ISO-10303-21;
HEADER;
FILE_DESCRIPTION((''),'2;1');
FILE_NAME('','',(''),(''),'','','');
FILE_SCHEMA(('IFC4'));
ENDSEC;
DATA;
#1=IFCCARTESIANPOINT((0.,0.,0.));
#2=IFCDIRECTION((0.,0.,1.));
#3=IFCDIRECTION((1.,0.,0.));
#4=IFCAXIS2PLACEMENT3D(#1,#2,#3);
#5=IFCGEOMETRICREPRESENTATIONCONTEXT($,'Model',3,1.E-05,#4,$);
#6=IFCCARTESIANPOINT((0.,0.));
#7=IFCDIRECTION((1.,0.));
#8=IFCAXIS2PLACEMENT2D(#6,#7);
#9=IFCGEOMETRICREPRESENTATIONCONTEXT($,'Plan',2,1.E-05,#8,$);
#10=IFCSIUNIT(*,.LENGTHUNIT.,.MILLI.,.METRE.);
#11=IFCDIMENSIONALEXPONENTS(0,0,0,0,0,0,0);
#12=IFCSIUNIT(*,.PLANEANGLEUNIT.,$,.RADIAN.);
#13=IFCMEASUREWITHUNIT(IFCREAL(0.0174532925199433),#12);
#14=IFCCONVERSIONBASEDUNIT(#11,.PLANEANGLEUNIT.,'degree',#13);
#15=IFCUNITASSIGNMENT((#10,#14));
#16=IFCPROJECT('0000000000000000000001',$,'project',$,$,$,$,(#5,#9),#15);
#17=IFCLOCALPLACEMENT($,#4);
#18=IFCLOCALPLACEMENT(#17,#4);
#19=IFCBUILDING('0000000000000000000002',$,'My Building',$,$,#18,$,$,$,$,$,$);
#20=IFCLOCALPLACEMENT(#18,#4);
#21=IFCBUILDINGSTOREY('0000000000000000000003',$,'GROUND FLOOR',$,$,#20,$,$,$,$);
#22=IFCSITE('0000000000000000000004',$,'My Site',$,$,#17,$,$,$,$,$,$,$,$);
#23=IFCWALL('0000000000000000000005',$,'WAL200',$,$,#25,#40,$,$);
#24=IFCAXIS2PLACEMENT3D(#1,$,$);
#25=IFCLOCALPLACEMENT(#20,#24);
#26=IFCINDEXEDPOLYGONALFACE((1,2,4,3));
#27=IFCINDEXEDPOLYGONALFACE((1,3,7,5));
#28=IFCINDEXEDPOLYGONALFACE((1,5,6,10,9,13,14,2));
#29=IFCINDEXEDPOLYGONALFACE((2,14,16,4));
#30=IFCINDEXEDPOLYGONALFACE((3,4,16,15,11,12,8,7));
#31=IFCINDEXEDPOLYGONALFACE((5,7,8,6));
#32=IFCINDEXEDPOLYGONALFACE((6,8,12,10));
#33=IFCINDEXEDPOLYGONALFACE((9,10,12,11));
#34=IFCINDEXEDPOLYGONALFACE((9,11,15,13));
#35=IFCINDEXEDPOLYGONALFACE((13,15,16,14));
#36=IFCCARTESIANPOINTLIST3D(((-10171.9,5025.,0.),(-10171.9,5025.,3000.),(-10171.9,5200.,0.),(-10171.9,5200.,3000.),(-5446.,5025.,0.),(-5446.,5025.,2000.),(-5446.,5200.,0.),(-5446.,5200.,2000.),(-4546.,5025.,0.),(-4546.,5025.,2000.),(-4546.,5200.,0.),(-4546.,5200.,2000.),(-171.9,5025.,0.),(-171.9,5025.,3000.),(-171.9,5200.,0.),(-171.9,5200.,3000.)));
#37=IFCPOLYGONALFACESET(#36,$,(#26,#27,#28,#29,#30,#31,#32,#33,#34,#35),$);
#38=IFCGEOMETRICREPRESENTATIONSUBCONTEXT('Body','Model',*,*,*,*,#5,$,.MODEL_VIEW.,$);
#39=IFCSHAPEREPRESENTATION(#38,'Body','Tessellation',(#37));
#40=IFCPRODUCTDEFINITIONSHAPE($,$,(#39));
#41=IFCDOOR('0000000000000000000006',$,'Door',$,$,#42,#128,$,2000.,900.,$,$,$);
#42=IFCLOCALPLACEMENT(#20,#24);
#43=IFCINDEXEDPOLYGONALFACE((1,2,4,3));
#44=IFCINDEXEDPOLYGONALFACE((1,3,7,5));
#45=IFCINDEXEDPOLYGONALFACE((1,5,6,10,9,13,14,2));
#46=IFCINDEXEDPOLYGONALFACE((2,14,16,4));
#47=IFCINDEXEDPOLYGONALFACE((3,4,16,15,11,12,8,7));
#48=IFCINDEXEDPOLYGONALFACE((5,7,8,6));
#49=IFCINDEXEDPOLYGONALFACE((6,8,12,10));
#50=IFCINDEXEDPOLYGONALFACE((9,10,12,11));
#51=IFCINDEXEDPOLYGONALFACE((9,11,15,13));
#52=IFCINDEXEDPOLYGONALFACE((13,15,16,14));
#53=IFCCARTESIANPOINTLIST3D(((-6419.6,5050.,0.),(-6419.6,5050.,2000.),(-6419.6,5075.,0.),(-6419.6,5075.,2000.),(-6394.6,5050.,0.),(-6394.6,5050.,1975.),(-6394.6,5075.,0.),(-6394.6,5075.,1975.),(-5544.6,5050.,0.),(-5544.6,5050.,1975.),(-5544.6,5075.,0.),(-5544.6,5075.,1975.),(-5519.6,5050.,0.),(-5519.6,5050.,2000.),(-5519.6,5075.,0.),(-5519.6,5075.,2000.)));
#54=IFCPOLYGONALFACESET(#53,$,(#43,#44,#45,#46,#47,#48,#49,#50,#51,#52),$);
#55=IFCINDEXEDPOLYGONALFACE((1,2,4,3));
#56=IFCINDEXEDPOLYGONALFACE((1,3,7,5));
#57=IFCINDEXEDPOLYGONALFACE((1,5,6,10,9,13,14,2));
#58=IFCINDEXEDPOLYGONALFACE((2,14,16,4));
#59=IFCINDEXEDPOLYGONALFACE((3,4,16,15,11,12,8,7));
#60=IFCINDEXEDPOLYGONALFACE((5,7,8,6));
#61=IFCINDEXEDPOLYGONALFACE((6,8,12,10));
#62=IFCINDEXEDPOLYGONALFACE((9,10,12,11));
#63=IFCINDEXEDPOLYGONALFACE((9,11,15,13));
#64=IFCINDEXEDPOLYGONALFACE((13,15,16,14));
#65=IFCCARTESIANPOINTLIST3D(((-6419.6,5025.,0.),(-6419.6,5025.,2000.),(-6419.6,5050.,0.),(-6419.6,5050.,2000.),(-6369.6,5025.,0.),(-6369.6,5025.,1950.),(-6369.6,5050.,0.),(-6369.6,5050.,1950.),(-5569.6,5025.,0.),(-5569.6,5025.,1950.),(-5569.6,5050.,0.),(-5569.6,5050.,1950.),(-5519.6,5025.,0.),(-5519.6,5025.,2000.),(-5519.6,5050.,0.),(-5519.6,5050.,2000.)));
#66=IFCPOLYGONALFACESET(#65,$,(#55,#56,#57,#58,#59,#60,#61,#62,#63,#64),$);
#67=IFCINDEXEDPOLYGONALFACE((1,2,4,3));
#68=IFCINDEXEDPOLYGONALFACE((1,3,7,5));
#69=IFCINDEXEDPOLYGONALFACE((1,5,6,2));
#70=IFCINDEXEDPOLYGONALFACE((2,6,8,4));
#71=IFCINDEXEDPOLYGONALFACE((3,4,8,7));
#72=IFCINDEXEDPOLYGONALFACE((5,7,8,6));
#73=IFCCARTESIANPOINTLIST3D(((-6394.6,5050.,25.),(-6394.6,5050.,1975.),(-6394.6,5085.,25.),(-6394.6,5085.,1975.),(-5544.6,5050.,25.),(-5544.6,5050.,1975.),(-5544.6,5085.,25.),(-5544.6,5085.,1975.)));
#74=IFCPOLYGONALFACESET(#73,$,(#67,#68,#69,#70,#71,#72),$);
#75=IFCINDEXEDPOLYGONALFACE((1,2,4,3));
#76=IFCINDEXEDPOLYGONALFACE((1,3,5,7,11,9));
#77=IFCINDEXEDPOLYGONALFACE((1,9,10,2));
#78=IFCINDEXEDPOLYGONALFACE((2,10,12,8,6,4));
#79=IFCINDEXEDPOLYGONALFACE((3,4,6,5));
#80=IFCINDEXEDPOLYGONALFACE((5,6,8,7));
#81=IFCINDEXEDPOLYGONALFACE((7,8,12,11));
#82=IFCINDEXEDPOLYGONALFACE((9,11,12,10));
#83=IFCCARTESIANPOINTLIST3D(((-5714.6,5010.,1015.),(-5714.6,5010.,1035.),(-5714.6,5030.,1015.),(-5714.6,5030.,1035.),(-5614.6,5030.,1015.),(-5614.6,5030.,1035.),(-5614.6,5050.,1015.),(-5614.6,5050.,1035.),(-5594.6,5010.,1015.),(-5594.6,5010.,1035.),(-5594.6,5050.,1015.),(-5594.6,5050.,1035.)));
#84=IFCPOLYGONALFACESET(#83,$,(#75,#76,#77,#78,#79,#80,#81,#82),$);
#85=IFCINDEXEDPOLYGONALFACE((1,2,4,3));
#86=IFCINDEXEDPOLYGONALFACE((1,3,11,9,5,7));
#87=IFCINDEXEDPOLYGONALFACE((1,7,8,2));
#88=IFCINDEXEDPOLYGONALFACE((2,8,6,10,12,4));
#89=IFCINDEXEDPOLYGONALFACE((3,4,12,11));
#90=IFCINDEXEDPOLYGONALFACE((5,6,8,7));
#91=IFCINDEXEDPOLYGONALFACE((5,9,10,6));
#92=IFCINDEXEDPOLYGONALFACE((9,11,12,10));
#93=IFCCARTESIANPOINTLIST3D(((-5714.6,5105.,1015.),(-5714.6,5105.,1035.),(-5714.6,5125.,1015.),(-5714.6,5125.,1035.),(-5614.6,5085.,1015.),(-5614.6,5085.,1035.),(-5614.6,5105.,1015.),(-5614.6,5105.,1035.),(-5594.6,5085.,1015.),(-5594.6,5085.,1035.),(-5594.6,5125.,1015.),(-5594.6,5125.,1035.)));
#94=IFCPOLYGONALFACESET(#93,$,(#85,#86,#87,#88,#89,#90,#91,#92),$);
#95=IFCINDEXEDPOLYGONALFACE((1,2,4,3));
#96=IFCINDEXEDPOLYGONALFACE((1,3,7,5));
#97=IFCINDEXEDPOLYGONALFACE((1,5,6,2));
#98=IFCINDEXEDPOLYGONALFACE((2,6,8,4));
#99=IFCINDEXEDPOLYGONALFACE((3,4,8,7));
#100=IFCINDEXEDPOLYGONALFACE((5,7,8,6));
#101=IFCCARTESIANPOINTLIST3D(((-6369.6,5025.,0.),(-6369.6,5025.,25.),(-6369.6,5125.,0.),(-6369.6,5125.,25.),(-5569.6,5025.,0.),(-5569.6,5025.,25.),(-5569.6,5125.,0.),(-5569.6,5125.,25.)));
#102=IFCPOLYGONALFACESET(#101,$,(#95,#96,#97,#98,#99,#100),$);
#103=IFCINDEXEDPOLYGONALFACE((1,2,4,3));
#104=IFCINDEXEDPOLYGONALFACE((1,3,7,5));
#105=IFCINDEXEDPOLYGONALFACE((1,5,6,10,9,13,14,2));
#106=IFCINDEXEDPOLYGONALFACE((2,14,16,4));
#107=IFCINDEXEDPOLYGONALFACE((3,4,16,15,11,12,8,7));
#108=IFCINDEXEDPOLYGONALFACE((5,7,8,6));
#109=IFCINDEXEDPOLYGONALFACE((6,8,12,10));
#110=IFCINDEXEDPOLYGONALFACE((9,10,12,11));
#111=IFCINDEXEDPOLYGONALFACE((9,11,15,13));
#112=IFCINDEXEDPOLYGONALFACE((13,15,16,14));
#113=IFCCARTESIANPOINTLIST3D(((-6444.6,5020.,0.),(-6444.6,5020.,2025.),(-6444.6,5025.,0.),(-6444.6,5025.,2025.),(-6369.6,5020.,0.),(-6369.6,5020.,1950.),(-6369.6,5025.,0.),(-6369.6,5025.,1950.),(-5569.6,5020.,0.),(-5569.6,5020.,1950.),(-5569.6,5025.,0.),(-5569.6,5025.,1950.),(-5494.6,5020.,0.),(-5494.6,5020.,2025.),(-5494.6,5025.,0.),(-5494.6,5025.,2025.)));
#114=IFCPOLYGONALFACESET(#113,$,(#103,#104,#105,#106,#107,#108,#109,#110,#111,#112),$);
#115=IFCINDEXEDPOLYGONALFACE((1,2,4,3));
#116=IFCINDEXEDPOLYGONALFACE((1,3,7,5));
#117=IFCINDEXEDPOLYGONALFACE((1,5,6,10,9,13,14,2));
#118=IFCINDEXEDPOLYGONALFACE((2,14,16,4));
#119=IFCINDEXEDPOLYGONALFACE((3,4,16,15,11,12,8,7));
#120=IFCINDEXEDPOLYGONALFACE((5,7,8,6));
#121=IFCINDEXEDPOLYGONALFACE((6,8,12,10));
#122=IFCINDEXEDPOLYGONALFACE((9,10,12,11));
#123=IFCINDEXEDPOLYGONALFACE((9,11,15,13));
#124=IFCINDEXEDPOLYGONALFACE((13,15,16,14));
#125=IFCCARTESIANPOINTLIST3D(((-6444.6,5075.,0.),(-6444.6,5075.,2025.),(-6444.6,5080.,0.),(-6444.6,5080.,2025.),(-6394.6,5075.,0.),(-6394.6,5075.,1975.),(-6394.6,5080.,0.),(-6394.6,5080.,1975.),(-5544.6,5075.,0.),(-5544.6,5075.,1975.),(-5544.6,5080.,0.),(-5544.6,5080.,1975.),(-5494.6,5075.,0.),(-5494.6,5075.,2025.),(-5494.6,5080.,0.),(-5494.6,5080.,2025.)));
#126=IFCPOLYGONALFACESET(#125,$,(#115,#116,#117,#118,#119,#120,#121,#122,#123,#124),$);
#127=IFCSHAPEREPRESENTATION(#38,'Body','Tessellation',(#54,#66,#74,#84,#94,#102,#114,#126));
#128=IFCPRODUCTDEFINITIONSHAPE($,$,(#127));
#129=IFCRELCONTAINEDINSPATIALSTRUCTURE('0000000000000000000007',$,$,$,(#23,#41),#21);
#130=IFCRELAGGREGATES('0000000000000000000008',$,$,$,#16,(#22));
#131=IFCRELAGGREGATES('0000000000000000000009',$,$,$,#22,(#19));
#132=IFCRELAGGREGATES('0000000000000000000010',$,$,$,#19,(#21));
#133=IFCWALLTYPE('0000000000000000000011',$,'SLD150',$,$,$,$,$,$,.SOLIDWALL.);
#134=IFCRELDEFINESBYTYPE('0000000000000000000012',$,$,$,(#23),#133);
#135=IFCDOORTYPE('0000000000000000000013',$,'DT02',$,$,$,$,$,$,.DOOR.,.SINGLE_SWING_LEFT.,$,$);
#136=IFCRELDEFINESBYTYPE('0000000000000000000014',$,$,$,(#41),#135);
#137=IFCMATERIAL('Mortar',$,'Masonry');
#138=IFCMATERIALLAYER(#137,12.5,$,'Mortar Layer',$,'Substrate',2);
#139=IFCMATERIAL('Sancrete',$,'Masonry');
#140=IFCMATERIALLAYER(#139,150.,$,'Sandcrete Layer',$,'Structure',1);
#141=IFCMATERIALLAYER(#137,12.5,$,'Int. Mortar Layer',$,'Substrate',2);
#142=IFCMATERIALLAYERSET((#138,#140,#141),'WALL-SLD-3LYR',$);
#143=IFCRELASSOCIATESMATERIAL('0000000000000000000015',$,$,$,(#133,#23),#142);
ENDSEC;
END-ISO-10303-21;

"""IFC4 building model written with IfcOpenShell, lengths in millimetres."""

from ifc_helpers import new_model, entity, si_unit, converted_unit, frame, origin_with_axes, origin_2d_with_axis, place, context, subcontext, project, spatial, line, indexed_curve, outline, extrude, shape, source, transform, mapped, material, layer, layer_set, layer_usage, type_object, type_shapes, element, fill, save


model = new_model("IFC4")

# Units and contexts
model_context = context("Model", 3, precision=1e-05, world=origin_with_axes())
plan_context = context("Plan", 2, precision=1e-05, world=origin_2d_with_axis())
body_context_1 = subcontext(model_context, "Body", "Model", "MODEL_VIEW")
body_context_2 = subcontext(plan_context, "Body", "Plan", "PLAN_VIEW")
ifc_project = project(units=[si_unit("LENGTHUNIT", "METRE", prefix="MILLI"), converted_unit("PLANEANGLEUNIT", "degree", entity("IfcReal", 0.0174532925199433), si_unit("PLANEANGLEUNIT", "RADIAN"), dimensions=[0, 0, 0, 0, 0, 0, 0])], contexts=[model_context, plan_context])

# Site, building, storey
site_placement = place(None, origin_with_axes())
site = spatial("IfcSite", under=ifc_project, at=site_placement, Name="My Site")
building_placement = place(site_placement, origin_with_axes())
building = spatial("IfcBuilding", under=site, at=building_placement, Name="My Building")
storey_placement = place(building_placement, origin_with_axes())
storey = spatial("IfcBuildingStorey", under=building, at=storey_placement, Name="GROUND FLOOR")

# Wall, opening, door
ifc_material_1 = material(Name="Mortar", Category="Masonry")
ifc_layer_1 = layer(ifc_material_1, 12.5, Name="Mortar Layer", Category="Substrate", Priority=2)
ifc_material_2 = material(Name="Sancrete", Category="Masonry")
ifc_layer_2 = layer(ifc_material_2, 150.0, Name="Sandcrete Layer", Category="Structure", Priority=1)
ifc_layer_3 = layer(ifc_material_1, 12.5, Name="Int. Mortar Layer", Category="Substrate", Priority=2)
ifc_layer_set_1 = layer_set([ifc_layer_1, ifc_layer_2, ifc_layer_3], Name="WALL-SLD-3LYR")
ifc_layer_usage_1 = layer_usage(ifc_layer_set_1, "AXIS2", "POSITIVE", 0.0)
wall_type = type_object("IfcWallType", Name="SLD150", PredefinedType="SOLIDWALL", material=ifc_layer_set_1)
wall_1_placement = place(storey_placement, frame((-10171.9, 5025.0, 0.0), z_axis=(0.0, 0.0, 1.0), x_axis=(1.0, 0.0, 0.0)))
wall_1 = element("IfcWall", 1, at=wall_1_placement, inside=storey, type_object=wall_type, material=ifc_layer_usage_1, Name="WAL200", context=body_context_1, shape_type="SweptSolid", body=[
    extrude(outline(indexed_curve([(0.0, 0.0), (0.0, 175.0), (10000.0, 175.0), (10000.0, 0.0), (0.0, 0.0)], self_intersect=False)), origin_with_axes(), (0.0, 0.0, 1.0), 3000.0),
])
shared_shape_1 = source(origin_with_axes(), body_context_1, "Body", "SweptSolid", [
    extrude(outline(indexed_curve([(0.0, 0.0), (900.0, 0.0), (900.0, 2000.0), (0.0, 2000.0)], segments=[line(1, 2), line(2, 3), line(3, 4), line(4, 1)])), frame((0.0, -100.0, 0.0), z_axis=(0.0, -1.0, 0.0), x_axis=(1.0, 0.0, 0.0)), (0.0, 0.0, -1.0), 300.0),
])
opening_1_placement = place(wall_1_placement, frame((4725.9, 0.0, 0.0), z_axis=(0.0, 0.0, 1.0), x_axis=(1.0, 0.0, 0.0)))
opening_1 = element("IfcOpeningElement", 2, at=opening_1_placement, cuts=wall_1, PredefinedType="OPENING", context=body_context_1, shape_type="MappedRepresentation", body=[
    mapped(shared_shape_1, transform((0.0, 0.0, 0.0), x_axis=(1.0, 0.0, 0.0), y_axis=(0.0, 1.0, 0.0), z_axis=(0.0, 0.0, 1.0), scale=1.0)),
])
door_type = type_object("IfcDoorType", Name="DT02", OperationType="SINGLE_SWING_LEFT", PredefinedType="DOOR")
shared_shape_2 = source(origin_with_axes(), body_context_1, "Body", "SweptSolid", [
    extrude(outline(indexed_curve([(0.0, 0.0), (0.0, 2000.0), (900.0, 2000.0), (900.0, 0.0), (875.0, 0.0), (875.0, 1975.0), (25.0, 1975.0), (25.0, 0.0)], segments=[line(1, 2), line(2, 3), line(3, 4), line(4, 5), line(5, 6), line(6, 7), line(7, 8), line(8, 1)])), frame((0.0, 25.0, 0.0), z_axis=(0.0, -1.0, 0.0), x_axis=(1.0, 0.0, 0.0)), (0.0, 0.0, -1.0), 25.0),
    extrude(outline(indexed_curve([(0.0, 0.0), (0.0, 2000.0), (900.0, 2000.0), (900.0, 0.0), (850.0, 0.0), (850.0, 1950.0), (50.0, 1950.0), (50.0, 0.0)], segments=[line(1, 2), line(2, 3), line(3, 4), line(4, 5), line(5, 6), line(6, 7), line(7, 8), line(8, 1)])), frame((0.0, 0.0, 0.0), z_axis=(0.0, -1.0, 0.0), x_axis=(1.0, 0.0, 0.0)), (0.0, 0.0, -1.0), 25.0),
    extrude(outline(indexed_curve([(0.0, 0.0), (850.0, 0.0), (850.0, 35.0), (0.0, 35.0)], segments=[line(1, 2), line(2, 3), line(3, 4), line(4, 1)])), frame((25.0, 25.0, 25.0), z_axis=(0.0, 0.0, 1.0), x_axis=(1.0, 0.0, 0.0)), (0.0, 0.0, 1.0), 1950.0),
    extrude(outline(indexed_curve([(0.0, 0.0), (0.0, -40.0), (-120.0, -40.0), (-120.0, -20.0), (-20.0, -20.0), (-20.0, 0.0)], segments=[line(1, 2), line(2, 3), line(3, 4), line(4, 5), line(5, 6), line(6, 1)])), frame((825.0, 25.0, 1015.0), z_axis=(0.0, 0.0, 1.0), x_axis=(1.0, 0.0, 0.0)), (0.0, 0.0, 1.0), 20.0),
    extrude(outline(indexed_curve([(0.0, 0.0), (0.0, 40.0), (-120.0, 40.0), (-120.0, 20.0), (-20.0, 20.0), (-20.0, 0.0)], segments=[line(1, 2), line(2, 3), line(3, 4), line(4, 5), line(5, 6), line(6, 1)])), frame((825.0, 60.0, 1015.0), z_axis=(0.0, 0.0, 1.0), x_axis=(1.0, 0.0, 0.0)), (0.0, 0.0, 1.0), 20.0),
    extrude(outline(indexed_curve([(0.0, 0.0), (800.0, 0.0), (800.0, 100.0), (0.0, 100.0)], segments=[line(1, 2), line(2, 3), line(3, 4), line(4, 1)])), frame((50.0, 0.0, 0.0), z_axis=(0.0, 0.0, 1.0), x_axis=(1.0, 0.0, 0.0)), (0.0, 0.0, 1.0), 25.0),
    extrude(outline(indexed_curve([(0.0, 0.0), (0.0, 2025.0), (950.0, 2025.0), (950.0, 0.0), (875.0, 0.0), (875.0, 1950.0), (75.0, 1950.0), (75.0, 0.0)], segments=[line(1, 2), line(2, 3), line(3, 4), line(4, 5), line(5, 6), line(6, 7), line(7, 8), line(8, 1)])), frame((-25.0, -5.0, 0.0), z_axis=(0.0, -1.0, 0.0), x_axis=(1.0, 0.0, 0.0)), (0.0, 0.0, -1.0), 5.0),
    extrude(outline(indexed_curve([(0.0, 0.0), (0.0, 2025.0), (950.0, 2025.0), (950.0, 0.0), (900.0, 0.0), (900.0, 1975.0), (50.0, 1975.0), (50.0, 0.0)], segments=[line(1, 2), line(2, 3), line(3, 4), line(4, 5), line(5, 6), line(6, 7), line(7, 8), line(8, 1)])), frame((-25.0, 50.0, 0.0), z_axis=(0.0, -1.0, 0.0), x_axis=(1.0, 0.0, 0.0)), (0.0, 0.0, -1.0), 5.0),
])
shared_shape_3 = source(origin_with_axes(), body_context_2, "Body", "Curve2D", [
    entity("IfcIndexedPolyCurve", entity("IfcCartesianPointList2D", [[0.0, 0.0], [0.0, 50.0], [25.0, 50.0], [25.0, 25.0], [50.0, 25.0], [50.0, 0.0]]), [entity("IfcLineIndex", [1, 2]), entity("IfcLineIndex", [2, 3]), entity("IfcLineIndex", [3, 4]), entity("IfcLineIndex", [4, 5]), entity("IfcLineIndex", [5, 6]), entity("IfcLineIndex", [6, 1])]),
    entity("IfcIndexedPolyCurve", entity("IfcCartesianPointList2D", [[900.0, 0.0], [900.0, 50.0], [875.0, 50.0], [875.0, 25.0], [850.0, 25.0], [850.0, 0.0]]), [entity("IfcLineIndex", [1, 2]), entity("IfcLineIndex", [2, 3]), entity("IfcLineIndex", [3, 4]), entity("IfcLineIndex", [4, 5]), entity("IfcLineIndex", [5, 6]), entity("IfcLineIndex", [6, 1])]),
    entity("IfcTrimmedCurve", entity("IfcEllipse", entity("IfcAxis2Placement2D", entity("IfcCartesianPoint", [60.0, 50.0]), entity("IfcDirection", [1.0, 0.0])), 815.0, 850.0), [entity("IfcCartesianPoint", [875.0, 50.0])], [entity("IfcCartesianPoint", [60.0, 900.0])], True, "CARTESIAN"),
    entity("IfcIndexedPolyCurve", entity("IfcCartesianPointList2D", [[25.0, 50.0], [60.0, 50.0], [60.0, 900.0], [25.0, 900.0]]), [entity("IfcLineIndex", [1, 2]), entity("IfcLineIndex", [2, 3]), entity("IfcLineIndex", [3, 4]), entity("IfcLineIndex", [4, 1])]),
])
type_shapes(door_type, [shared_shape_2, shared_shape_3])
door_1_placement = place(opening_1_placement, frame((-973.6, 0.0, 0.0), z_axis=(0.0, 0.0, 1.0), x_axis=(1.0, 0.0, 0.0)))
door_1 = element("IfcDoor", 3, at=door_1_placement, inside=storey, type_object=door_type, Name="Door", OverallHeight=2000.0, OverallWidth=900.0, shapes=[
    shape(body_context_1, "Body", "MappedRepresentation", [mapped(shared_shape_2, transform((0.0, 0.0, 0.0), x_axis=(1.0, 0.0, 0.0), y_axis=(0.0, 1.0, 0.0), z_axis=(0.0, 0.0, 1.0), scale=1.0))]),
    shape(body_context_2, "Body", "MappedRepresentation", [mapped(shared_shape_3, transform((0.0, 0.0, 0.0), x_axis=(1.0, 0.0, 0.0), y_axis=(0.0, 1.0, 0.0), z_axis=(0.0, 0.0, 1.0), scale=1.0))]),
])
fill(opening_1, door_1)

save(model, "model.ifc")
